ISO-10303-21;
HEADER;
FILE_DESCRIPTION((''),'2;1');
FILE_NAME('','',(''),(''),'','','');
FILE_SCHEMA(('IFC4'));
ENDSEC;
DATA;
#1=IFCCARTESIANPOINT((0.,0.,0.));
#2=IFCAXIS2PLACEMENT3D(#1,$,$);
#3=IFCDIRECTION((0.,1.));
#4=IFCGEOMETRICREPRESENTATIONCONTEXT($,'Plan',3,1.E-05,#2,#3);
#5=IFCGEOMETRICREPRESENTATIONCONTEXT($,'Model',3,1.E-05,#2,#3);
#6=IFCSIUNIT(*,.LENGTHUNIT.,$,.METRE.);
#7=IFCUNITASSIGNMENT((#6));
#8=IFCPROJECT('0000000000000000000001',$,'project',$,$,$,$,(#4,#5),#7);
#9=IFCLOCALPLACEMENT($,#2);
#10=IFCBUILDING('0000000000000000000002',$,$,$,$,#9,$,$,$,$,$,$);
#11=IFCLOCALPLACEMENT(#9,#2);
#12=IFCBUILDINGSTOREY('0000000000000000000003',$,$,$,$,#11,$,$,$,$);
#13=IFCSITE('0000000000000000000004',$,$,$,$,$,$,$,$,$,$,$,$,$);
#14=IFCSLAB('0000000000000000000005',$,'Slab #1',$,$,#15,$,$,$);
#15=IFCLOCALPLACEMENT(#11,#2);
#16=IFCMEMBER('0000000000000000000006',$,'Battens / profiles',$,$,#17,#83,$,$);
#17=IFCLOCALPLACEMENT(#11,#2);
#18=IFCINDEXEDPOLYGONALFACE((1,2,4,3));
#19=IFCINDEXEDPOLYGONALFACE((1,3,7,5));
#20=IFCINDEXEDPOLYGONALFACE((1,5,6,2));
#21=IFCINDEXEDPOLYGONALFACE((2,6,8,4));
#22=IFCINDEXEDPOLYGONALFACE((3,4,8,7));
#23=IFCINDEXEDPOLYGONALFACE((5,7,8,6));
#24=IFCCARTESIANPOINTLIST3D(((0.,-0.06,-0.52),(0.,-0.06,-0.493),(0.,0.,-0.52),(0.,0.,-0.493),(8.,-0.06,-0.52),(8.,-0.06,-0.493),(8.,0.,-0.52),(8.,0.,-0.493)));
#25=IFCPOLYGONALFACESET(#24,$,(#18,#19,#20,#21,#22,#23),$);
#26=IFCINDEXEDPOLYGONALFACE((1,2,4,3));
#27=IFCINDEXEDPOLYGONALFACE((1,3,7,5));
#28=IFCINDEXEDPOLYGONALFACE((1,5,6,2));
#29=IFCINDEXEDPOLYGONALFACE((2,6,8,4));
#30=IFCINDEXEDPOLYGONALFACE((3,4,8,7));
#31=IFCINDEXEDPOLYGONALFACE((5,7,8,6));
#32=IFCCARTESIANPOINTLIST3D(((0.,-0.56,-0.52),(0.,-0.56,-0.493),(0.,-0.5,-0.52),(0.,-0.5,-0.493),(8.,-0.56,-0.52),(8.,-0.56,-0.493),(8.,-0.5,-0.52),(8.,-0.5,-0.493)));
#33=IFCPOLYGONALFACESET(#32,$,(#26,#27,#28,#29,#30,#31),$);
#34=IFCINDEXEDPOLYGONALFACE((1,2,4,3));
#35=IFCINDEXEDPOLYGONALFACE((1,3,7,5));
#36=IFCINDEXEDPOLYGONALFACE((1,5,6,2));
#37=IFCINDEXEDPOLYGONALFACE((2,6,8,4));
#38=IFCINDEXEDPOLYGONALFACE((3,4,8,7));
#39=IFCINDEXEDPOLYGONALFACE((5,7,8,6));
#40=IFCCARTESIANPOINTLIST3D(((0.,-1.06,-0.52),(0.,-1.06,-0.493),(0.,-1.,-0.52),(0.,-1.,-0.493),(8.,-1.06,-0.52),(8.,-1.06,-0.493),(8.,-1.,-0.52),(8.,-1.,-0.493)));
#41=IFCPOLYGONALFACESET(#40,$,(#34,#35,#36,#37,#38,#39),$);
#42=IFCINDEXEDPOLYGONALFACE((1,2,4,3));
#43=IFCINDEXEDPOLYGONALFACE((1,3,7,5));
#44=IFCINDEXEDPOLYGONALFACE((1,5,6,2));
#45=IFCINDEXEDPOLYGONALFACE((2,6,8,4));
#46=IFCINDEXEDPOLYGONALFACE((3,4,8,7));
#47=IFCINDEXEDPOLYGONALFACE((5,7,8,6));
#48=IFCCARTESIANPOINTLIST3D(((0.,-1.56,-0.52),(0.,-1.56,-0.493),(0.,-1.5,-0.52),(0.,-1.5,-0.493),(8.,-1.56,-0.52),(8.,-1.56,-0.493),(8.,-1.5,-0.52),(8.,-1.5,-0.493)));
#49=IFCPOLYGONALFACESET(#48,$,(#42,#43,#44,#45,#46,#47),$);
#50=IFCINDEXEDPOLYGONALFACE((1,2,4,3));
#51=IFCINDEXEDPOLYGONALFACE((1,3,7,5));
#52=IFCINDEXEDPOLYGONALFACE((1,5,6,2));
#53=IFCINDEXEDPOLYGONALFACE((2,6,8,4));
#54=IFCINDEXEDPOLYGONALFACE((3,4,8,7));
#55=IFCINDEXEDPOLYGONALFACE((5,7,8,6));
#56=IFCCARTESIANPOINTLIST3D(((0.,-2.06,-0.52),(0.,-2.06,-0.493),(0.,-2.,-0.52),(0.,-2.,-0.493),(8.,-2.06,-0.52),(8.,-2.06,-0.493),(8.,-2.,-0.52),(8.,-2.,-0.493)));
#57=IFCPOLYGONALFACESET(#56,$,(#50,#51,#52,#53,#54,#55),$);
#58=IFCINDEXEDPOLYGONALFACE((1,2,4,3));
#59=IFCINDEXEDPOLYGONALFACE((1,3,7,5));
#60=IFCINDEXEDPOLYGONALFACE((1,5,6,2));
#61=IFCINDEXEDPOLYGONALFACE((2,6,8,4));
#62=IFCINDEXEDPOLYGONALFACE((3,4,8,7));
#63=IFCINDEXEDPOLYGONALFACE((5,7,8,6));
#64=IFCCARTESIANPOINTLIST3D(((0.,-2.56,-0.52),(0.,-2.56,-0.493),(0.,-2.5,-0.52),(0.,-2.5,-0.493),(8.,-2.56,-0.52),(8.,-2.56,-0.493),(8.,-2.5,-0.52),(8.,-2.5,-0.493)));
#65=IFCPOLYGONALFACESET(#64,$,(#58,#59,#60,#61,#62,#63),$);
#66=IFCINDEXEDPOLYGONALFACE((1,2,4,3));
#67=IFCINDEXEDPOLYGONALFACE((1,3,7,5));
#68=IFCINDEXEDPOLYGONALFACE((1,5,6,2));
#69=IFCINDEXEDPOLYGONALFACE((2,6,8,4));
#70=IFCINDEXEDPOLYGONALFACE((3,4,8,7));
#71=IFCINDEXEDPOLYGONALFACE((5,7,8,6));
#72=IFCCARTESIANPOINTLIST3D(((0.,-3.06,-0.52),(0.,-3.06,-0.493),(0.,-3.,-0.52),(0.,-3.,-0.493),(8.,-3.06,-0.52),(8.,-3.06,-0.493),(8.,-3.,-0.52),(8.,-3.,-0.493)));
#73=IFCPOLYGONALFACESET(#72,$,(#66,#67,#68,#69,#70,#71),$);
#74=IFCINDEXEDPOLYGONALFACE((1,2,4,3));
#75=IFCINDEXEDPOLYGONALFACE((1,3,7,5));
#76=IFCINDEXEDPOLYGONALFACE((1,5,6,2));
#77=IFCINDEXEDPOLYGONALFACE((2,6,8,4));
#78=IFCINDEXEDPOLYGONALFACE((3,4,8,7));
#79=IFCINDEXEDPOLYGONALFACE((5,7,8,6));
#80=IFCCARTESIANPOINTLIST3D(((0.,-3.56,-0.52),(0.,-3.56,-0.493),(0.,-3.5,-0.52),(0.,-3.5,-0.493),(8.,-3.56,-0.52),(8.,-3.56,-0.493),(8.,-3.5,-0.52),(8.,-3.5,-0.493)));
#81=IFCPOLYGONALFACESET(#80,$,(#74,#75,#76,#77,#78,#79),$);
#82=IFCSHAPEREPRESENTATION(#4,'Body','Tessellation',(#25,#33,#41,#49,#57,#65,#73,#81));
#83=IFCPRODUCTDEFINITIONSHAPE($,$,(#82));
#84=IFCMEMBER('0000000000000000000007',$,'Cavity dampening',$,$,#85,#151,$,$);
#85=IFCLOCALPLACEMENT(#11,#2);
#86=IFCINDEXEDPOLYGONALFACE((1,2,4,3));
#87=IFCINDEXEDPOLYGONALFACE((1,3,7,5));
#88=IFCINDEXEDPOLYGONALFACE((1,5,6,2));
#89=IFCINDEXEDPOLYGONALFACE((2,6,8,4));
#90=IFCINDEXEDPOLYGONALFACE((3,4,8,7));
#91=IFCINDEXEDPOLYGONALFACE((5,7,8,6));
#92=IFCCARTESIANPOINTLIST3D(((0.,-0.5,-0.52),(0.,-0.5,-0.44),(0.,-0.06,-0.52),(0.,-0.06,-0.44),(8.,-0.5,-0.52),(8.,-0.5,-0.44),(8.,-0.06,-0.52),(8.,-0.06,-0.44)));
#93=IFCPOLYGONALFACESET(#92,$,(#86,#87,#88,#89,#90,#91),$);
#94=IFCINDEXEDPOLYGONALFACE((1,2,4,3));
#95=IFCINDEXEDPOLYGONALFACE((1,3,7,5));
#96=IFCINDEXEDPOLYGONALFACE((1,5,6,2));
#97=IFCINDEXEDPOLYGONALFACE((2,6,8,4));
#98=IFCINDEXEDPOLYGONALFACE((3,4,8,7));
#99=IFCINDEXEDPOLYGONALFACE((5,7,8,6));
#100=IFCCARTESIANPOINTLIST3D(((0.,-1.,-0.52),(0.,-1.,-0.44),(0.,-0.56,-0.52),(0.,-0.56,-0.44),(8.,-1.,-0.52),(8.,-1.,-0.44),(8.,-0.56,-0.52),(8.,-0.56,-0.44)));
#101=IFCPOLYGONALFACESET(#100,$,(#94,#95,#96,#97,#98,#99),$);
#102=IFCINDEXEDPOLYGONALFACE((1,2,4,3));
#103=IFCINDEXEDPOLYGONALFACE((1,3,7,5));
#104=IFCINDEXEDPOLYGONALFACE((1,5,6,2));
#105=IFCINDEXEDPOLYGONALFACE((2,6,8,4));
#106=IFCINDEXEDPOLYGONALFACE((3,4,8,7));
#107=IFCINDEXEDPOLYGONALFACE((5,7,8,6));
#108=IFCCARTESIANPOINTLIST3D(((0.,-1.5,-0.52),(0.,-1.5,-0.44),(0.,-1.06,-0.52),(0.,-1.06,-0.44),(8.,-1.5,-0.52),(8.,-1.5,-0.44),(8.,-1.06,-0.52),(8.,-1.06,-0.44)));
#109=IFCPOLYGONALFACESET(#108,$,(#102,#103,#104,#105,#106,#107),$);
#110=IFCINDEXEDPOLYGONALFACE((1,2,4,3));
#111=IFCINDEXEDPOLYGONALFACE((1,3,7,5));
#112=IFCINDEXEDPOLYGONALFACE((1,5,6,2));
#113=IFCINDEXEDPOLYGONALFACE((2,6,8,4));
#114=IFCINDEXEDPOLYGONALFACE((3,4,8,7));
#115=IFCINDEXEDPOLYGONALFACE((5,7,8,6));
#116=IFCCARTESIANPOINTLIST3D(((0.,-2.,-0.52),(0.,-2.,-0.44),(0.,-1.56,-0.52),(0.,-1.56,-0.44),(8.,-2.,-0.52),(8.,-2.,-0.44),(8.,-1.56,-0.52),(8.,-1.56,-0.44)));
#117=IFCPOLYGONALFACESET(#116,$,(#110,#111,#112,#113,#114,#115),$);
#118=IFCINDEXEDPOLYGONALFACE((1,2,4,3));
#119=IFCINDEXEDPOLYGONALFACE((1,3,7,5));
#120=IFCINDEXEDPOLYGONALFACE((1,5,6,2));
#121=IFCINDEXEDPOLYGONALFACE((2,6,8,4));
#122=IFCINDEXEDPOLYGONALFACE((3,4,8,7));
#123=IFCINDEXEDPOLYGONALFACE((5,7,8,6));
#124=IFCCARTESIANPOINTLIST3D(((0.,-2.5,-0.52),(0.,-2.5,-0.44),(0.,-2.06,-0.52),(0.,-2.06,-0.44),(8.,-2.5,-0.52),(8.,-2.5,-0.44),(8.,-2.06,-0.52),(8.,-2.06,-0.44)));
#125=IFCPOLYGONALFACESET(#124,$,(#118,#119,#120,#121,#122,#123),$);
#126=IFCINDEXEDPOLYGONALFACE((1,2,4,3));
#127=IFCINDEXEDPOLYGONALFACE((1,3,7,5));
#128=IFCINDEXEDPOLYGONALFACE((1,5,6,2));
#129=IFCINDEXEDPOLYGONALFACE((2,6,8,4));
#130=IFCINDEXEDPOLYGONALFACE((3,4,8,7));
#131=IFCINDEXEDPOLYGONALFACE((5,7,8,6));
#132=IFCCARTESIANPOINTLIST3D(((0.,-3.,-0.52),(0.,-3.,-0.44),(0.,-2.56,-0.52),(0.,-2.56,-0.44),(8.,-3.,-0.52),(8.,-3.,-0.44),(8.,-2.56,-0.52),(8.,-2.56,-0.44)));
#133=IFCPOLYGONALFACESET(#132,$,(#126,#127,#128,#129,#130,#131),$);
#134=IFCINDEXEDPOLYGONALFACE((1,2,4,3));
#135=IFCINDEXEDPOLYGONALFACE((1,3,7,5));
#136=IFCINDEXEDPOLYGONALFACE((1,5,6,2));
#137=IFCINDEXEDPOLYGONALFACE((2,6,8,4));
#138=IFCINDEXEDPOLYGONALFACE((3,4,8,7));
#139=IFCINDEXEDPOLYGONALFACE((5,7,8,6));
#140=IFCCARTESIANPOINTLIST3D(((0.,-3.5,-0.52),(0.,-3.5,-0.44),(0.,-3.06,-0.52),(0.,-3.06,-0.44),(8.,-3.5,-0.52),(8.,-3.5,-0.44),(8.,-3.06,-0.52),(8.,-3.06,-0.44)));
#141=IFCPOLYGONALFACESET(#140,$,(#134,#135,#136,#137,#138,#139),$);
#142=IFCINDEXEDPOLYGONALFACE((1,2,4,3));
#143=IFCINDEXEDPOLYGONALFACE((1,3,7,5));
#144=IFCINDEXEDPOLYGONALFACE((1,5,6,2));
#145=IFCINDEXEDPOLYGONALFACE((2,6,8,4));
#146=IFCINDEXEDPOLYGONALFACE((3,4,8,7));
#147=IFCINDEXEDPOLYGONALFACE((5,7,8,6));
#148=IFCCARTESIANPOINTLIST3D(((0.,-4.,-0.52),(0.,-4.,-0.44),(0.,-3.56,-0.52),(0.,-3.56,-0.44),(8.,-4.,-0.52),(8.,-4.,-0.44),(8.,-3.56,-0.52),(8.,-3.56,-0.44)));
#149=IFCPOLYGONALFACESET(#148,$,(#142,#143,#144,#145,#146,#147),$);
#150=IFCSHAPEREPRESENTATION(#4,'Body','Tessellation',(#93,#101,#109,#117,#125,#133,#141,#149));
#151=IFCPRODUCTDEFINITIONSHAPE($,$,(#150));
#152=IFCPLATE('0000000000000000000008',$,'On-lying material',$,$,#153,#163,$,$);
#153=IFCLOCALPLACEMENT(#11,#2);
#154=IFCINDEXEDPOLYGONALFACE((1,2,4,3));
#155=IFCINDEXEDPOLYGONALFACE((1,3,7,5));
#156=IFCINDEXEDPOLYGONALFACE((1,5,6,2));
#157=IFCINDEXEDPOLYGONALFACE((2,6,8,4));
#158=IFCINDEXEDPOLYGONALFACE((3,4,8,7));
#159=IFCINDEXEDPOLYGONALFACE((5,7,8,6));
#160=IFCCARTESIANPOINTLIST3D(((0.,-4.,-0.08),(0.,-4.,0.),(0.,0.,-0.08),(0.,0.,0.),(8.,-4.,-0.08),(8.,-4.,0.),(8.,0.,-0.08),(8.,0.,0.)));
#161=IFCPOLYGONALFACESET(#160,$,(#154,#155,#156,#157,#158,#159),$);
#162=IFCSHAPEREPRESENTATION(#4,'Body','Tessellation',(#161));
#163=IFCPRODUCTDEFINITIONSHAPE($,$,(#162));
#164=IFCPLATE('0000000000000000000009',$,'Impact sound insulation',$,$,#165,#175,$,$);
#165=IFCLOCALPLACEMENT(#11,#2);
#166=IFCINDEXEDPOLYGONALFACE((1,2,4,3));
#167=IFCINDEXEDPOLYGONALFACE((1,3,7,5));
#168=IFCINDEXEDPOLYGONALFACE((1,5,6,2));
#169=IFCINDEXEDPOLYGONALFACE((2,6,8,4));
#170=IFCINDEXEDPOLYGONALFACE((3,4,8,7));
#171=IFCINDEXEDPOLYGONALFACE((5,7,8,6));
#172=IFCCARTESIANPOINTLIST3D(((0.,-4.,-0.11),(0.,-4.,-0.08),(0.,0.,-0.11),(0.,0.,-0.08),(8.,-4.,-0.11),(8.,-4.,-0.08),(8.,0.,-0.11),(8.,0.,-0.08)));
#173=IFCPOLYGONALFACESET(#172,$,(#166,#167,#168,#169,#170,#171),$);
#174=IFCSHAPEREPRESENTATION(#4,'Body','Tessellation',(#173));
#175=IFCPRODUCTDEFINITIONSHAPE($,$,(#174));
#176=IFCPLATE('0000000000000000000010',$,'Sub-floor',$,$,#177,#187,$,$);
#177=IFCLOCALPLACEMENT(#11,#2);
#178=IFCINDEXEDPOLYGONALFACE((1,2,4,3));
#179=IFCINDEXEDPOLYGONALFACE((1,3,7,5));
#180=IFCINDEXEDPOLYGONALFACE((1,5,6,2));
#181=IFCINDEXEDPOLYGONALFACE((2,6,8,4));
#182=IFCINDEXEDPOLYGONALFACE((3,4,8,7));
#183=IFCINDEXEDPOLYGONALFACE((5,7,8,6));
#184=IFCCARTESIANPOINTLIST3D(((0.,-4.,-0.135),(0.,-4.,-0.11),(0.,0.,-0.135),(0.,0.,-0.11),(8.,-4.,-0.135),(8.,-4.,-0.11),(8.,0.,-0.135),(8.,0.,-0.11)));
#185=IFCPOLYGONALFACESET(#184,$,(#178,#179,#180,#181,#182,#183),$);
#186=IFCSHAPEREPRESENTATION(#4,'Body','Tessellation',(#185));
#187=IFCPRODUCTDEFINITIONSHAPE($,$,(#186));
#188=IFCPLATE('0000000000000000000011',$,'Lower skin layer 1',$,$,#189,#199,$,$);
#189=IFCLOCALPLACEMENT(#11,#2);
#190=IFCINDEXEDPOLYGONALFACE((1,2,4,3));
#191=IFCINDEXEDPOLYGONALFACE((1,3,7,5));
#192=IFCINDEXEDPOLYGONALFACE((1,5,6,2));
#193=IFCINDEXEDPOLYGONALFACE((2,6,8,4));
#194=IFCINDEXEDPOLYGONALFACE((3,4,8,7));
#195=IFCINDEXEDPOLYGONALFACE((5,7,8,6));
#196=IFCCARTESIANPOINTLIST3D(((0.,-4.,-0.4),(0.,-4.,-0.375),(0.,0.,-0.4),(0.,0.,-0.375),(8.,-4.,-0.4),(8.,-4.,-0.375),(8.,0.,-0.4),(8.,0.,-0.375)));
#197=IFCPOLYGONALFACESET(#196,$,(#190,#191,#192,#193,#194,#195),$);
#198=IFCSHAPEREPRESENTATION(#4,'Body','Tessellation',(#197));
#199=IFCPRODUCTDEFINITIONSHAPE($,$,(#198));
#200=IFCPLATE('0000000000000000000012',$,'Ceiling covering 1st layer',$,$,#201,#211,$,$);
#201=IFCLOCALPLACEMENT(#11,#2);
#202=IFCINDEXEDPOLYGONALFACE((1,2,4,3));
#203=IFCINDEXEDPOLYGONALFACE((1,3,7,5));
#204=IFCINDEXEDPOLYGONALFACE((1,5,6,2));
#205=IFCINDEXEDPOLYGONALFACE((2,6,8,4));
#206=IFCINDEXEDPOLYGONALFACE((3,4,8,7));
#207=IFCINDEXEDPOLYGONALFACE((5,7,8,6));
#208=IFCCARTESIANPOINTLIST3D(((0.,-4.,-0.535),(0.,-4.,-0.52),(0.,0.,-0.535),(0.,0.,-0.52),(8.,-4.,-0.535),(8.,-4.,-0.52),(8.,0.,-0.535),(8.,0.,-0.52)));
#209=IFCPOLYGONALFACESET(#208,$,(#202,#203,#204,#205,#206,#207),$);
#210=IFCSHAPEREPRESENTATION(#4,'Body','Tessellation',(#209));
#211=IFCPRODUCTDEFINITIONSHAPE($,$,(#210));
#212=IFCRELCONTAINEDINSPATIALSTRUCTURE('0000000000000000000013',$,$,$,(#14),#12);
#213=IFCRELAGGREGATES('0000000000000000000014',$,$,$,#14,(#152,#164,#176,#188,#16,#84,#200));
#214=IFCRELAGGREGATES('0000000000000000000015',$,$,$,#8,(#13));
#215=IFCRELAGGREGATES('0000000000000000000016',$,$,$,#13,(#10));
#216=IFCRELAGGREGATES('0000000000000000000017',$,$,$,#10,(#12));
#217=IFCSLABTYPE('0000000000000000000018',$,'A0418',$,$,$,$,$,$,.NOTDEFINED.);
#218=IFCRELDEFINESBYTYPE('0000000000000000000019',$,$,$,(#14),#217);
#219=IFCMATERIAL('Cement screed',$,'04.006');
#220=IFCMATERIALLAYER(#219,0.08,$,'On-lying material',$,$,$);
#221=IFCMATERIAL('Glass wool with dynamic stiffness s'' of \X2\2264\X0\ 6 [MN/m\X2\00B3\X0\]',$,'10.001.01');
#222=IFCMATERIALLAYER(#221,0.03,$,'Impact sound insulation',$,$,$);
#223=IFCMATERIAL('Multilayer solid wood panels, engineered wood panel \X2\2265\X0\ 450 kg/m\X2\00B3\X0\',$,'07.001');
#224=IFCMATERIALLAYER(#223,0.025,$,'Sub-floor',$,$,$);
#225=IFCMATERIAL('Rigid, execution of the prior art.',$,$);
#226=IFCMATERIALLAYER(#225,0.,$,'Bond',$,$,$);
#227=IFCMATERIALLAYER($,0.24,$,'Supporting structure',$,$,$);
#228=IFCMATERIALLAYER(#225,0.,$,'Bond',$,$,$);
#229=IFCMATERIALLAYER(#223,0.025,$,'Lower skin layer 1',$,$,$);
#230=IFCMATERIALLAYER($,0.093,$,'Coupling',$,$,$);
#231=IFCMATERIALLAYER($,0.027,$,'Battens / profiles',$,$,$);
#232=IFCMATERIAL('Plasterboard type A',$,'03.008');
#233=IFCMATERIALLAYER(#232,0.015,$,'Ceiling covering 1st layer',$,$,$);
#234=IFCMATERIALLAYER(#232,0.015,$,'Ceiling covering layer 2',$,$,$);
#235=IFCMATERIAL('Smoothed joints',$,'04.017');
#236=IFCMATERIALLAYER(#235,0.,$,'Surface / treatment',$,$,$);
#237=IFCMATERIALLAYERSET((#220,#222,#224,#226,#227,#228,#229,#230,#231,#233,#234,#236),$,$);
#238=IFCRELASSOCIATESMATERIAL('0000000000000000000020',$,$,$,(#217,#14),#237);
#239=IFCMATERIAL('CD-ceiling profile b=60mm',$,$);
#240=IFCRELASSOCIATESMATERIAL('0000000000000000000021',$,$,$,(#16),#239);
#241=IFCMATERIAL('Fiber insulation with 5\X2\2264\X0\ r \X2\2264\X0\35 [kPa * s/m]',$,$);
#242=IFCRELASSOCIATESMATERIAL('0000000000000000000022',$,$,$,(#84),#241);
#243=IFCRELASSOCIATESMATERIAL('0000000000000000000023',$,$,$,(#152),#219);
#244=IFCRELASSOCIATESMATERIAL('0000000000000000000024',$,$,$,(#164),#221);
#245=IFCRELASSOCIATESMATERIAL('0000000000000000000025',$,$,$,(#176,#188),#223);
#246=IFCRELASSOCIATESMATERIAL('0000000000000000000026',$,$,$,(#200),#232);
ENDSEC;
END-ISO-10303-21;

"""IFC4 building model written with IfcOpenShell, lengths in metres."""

from ifc_helpers import new_model, si_unit, direction, frame, frame_2d, origin, origin_with_axes, place, context, project, spatial, rectangle, extrude, material, layer, layer_set, type_object, element, aggregate, save


model = new_model("IFC4")

# Units and contexts
plan_context = context("Plan", 3, precision=1e-05, world=origin(), true_north=direction((0.0, 1.0)))
model_context = context("Model", 3, precision=1e-05, world=origin(), true_north=direction((0.0, 1.0)))
ifc_project = project(units=[si_unit("LENGTHUNIT", "METRE")], contexts=[plan_context, model_context])

# Site, building, storey
site = spatial("IfcSite", under=ifc_project)
building_placement = place(None, origin())
building = spatial("IfcBuilding", under=site, at=building_placement)
storey_placement = place(building_placement, origin())
storey = spatial("IfcBuildingStorey", under=building, at=storey_placement)

# Slab, members, plates
ifc_material_1 = material(Name="Cement screed", Category="04.006")
ifc_layer_1 = layer(ifc_material_1, 0.08, Name="On-lying material")
ifc_material_2 = material(Name="Glass wool with dynamic stiffness s' of ≤ 6 [MN/m³]", Category="10.001.01")
ifc_layer_2 = layer(ifc_material_2, 0.03, Name="Impact sound insulation")
ifc_material_3 = material(Name="Multilayer solid wood panels, engineered wood panel ≥ 450 kg/m³", Category="07.001")
ifc_layer_3 = layer(ifc_material_3, 0.025, Name="Sub-floor")
ifc_material_4 = material(Name="Rigid, execution of the prior art.")
ifc_layer_4 = layer(ifc_material_4, 0.0, Name="Bond")
ifc_layer_5 = layer(None, 0.24, Name="Supporting structure")
ifc_layer_6 = layer(ifc_material_4, 0.0, Name="Bond")
ifc_layer_7 = layer(ifc_material_3, 0.025, Name="Lower skin layer 1")
ifc_layer_8 = layer(None, 0.093, Name="Coupling")
ifc_layer_9 = layer(None, 0.027, Name="Battens / profiles")
ifc_material_5 = material(Name="Plasterboard type A", Category="03.008")
ifc_layer_10 = layer(ifc_material_5, 0.015, Name="Ceiling covering 1st layer")
ifc_layer_11 = layer(ifc_material_5, 0.015, Name="Ceiling covering layer 2")
ifc_material_6 = material(Name="Smoothed joints", Category="04.017")
ifc_layer_12 = layer(ifc_material_6, 0.0, Name="Surface / treatment")
ifc_layer_set = layer_set([ifc_layer_1, ifc_layer_2, ifc_layer_3, ifc_layer_4, ifc_layer_5, ifc_layer_6, ifc_layer_7, ifc_layer_8, ifc_layer_9, ifc_layer_10, ifc_layer_11, ifc_layer_12])
slab_type = type_object("IfcSlabType", Name="A0418", PredefinedType="NOTDEFINED", material=ifc_layer_set)
slab_placement = place(None, frame((0.0, 0.0, 0.0), z_axis=(0.0, 0.0, -1.0), x_axis=(1.0, 0.0, 0.0)))
slab = element("IfcSlab", 1, at=slab_placement, inside=storey, type_object=slab_type, material=ifc_layer_set, Name="Slab #1")
ifc_material_7 = material(Name="Fiber insulation with 5≤ r ≤35 [kPa * s/m]")
ifc_material_8 = material(Name="CD-ceiling profile b=60mm")
member_1_placement = place(slab_placement, origin())
member_1 = element("IfcMember", 2, at=member_1_placement, material=ifc_material_8, Name="Battens / profiles", context=plan_context, shape_type="SweptSolid", body=[
    extrude(rectangle(XDim=0.06, YDim=0.027, at=frame_2d((0.03, 0.0135), x_axis=(1.0, 0.0))), frame((0.0, 0.0, 0.493), z_axis=(1.0, 0.0, 0.0), x_axis=(0.0, 1.0, 0.0)), (0.0, 0.0, 1.0), 8.0),
    extrude(rectangle(XDim=0.06, YDim=0.027, at=frame_2d((0.03, 0.0135), x_axis=(1.0, 0.0))), frame((0.0, 0.5, 0.493), z_axis=(1.0, 0.0, 0.0), x_axis=(0.0, 1.0, 0.0)), (0.0, 0.0, 1.0), 8.0),
    extrude(rectangle(XDim=0.06, YDim=0.027, at=frame_2d((0.03, 0.0135), x_axis=(1.0, 0.0))), frame((0.0, 1.0, 0.493), z_axis=(1.0, 0.0, 0.0), x_axis=(0.0, 1.0, 0.0)), (0.0, 0.0, 1.0), 8.0),
    extrude(rectangle(XDim=0.06, YDim=0.027, at=frame_2d((0.03, 0.0135), x_axis=(1.0, 0.0))), frame((0.0, 1.5, 0.493), z_axis=(1.0, 0.0, 0.0), x_axis=(0.0, 1.0, 0.0)), (0.0, 0.0, 1.0), 8.0),
    extrude(rectangle(XDim=0.06, YDim=0.027, at=frame_2d((0.03, 0.0135), x_axis=(1.0, 0.0))), frame((0.0, 2.0, 0.493), z_axis=(1.0, 0.0, 0.0), x_axis=(0.0, 1.0, 0.0)), (0.0, 0.0, 1.0), 8.0),
    extrude(rectangle(XDim=0.06, YDim=0.027, at=frame_2d((0.03, 0.0135), x_axis=(1.0, 0.0))), frame((0.0, 2.5, 0.493), z_axis=(1.0, 0.0, 0.0), x_axis=(0.0, 1.0, 0.0)), (0.0, 0.0, 1.0), 8.0),
    extrude(rectangle(XDim=0.06, YDim=0.027, at=frame_2d((0.03, 0.0135), x_axis=(1.0, 0.0))), frame((0.0, 3.0, 0.493), z_axis=(1.0, 0.0, 0.0), x_axis=(0.0, 1.0, 0.0)), (0.0, 0.0, 1.0), 8.0),
    extrude(rectangle(XDim=0.06, YDim=0.027, at=frame_2d((0.03, 0.0135), x_axis=(1.0, 0.0))), frame((0.0, 3.5, 0.493), z_axis=(1.0, 0.0, 0.0), x_axis=(0.0, 1.0, 0.0)), (0.0, 0.0, 1.0), 8.0),
])
member_2_placement = place(slab_placement, origin())
member_2 = element("IfcMember", 3, at=member_2_placement, material=ifc_material_7, Name="Cavity dampening", context=plan_context, shape_type="SweptSolid", body=[
    extrude(rectangle(XDim=0.44, YDim=0.08, at=frame_2d((0.22, 0.04), x_axis=(1.0, 0.0))), frame((0.0, 0.06, 0.44), z_axis=(1.0, 0.0, 0.0), x_axis=(0.0, 1.0, 0.0)), (0.0, 0.0, 1.0), 8.0),
    extrude(rectangle(XDim=0.44, YDim=0.08, at=frame_2d((0.22, 0.04), x_axis=(1.0, 0.0))), frame((0.0, 0.56, 0.44), z_axis=(1.0, 0.0, 0.0), x_axis=(0.0, 1.0, 0.0)), (0.0, 0.0, 1.0), 8.0),
    extrude(rectangle(XDim=0.44, YDim=0.08, at=frame_2d((0.22, 0.04), x_axis=(1.0, 0.0))), frame((0.0, 1.06, 0.44), z_axis=(1.0, 0.0, 0.0), x_axis=(0.0, 1.0, 0.0)), (0.0, 0.0, 1.0), 8.0),
    extrude(rectangle(XDim=0.44, YDim=0.08, at=frame_2d((0.22, 0.04), x_axis=(1.0, 0.0))), frame((0.0, 1.56, 0.44), z_axis=(1.0, 0.0, 0.0), x_axis=(0.0, 1.0, 0.0)), (0.0, 0.0, 1.0), 8.0),
    extrude(rectangle(XDim=0.44, YDim=0.08, at=frame_2d((0.22, 0.04), x_axis=(1.0, 0.0))), frame((0.0, 2.06, 0.44), z_axis=(1.0, 0.0, 0.0), x_axis=(0.0, 1.0, 0.0)), (0.0, 0.0, 1.0), 8.0),
    extrude(rectangle(XDim=0.44, YDim=0.08, at=frame_2d((0.22, 0.04), x_axis=(1.0, 0.0))), frame((0.0, 2.56, 0.44), z_axis=(1.0, 0.0, 0.0), x_axis=(0.0, 1.0, 0.0)), (0.0, 0.0, 1.0), 8.0),
    extrude(rectangle(XDim=0.44, YDim=0.08, at=frame_2d((0.22, 0.04), x_axis=(1.0, 0.0))), frame((0.0, 3.06, 0.44), z_axis=(1.0, 0.0, 0.0), x_axis=(0.0, 1.0, 0.0)), (0.0, 0.0, 1.0), 8.0),
    extrude(rectangle(XDim=0.44, YDim=0.08, at=frame_2d((0.22, 0.04), x_axis=(1.0, 0.0))), frame((0.0, 3.56, 0.44), z_axis=(1.0, 0.0, 0.0), x_axis=(0.0, 1.0, 0.0)), (0.0, 0.0, 1.0), 8.0),
])
plate_1_placement = place(slab_placement, origin())
plate_1 = element("IfcPlate", 4, at=plate_1_placement, material=ifc_material_1, Name="On-lying material", context=plan_context, shape_type="SweptSolid", body=[
    extrude(rectangle(XDim=8.0, YDim=4.0, at=frame_2d((4.0, 2.0), x_axis=(1.0, 0.0))), origin_with_axes(), (0.0, 0.0, 1.0), 0.08),
])
plate_2_placement = place(slab_placement, origin())
plate_2 = element("IfcPlate", 5, at=plate_2_placement, material=ifc_material_2, Name="Impact sound insulation", context=plan_context, shape_type="SweptSolid", body=[
    extrude(rectangle(XDim=8.0, YDim=4.0, at=frame_2d((4.0, 2.0), x_axis=(1.0, 0.0))), frame((0.0, 0.0, 0.08), z_axis=(0.0, 0.0, 1.0), x_axis=(1.0, 0.0, 0.0)), (0.0, 0.0, 1.0), 0.03),
])
plate_3_placement = place(slab_placement, origin())
plate_3 = element("IfcPlate", 6, at=plate_3_placement, material=ifc_material_3, Name="Sub-floor", context=plan_context, shape_type="SweptSolid", body=[
    extrude(rectangle(XDim=8.0, YDim=4.0, at=frame_2d((4.0, 2.0), x_axis=(1.0, 0.0))), frame((0.0, 0.0, 0.11), z_axis=(0.0, 0.0, 1.0), x_axis=(1.0, 0.0, 0.0)), (0.0, 0.0, 1.0), 0.025),
])
plate_4_placement = place(slab_placement, origin())
plate_4 = element("IfcPlate", 7, at=plate_4_placement, material=ifc_material_3, Name="Lower skin layer 1", context=plan_context, shape_type="SweptSolid", body=[
    extrude(rectangle(XDim=8.0, YDim=4.0, at=frame_2d((4.0, 2.0), x_axis=(1.0, 0.0))), frame((0.0, 0.0, 0.375), z_axis=(0.0, 0.0, 1.0), x_axis=(1.0, 0.0, 0.0)), (0.0, 0.0, 1.0), 0.025),
])
plate_5_placement = place(slab_placement, origin())
plate_5 = element("IfcPlate", 8, at=plate_5_placement, material=ifc_material_5, Name="Ceiling covering 1st layer", context=plan_context, shape_type="SweptSolid", body=[
    extrude(rectangle(XDim=8.0, YDim=4.0, at=frame_2d((4.0, 2.0), x_axis=(1.0, 0.0))), frame((0.0, 0.0, 0.52), z_axis=(0.0, 0.0, 1.0), x_axis=(1.0, 0.0, 0.0)), (0.0, 0.0, 1.0), 0.015),
])
aggregate(slab, [plate_1, plate_2, plate_3, plate_4, member_1, member_2, plate_5])

save(model, "model.ifc")
